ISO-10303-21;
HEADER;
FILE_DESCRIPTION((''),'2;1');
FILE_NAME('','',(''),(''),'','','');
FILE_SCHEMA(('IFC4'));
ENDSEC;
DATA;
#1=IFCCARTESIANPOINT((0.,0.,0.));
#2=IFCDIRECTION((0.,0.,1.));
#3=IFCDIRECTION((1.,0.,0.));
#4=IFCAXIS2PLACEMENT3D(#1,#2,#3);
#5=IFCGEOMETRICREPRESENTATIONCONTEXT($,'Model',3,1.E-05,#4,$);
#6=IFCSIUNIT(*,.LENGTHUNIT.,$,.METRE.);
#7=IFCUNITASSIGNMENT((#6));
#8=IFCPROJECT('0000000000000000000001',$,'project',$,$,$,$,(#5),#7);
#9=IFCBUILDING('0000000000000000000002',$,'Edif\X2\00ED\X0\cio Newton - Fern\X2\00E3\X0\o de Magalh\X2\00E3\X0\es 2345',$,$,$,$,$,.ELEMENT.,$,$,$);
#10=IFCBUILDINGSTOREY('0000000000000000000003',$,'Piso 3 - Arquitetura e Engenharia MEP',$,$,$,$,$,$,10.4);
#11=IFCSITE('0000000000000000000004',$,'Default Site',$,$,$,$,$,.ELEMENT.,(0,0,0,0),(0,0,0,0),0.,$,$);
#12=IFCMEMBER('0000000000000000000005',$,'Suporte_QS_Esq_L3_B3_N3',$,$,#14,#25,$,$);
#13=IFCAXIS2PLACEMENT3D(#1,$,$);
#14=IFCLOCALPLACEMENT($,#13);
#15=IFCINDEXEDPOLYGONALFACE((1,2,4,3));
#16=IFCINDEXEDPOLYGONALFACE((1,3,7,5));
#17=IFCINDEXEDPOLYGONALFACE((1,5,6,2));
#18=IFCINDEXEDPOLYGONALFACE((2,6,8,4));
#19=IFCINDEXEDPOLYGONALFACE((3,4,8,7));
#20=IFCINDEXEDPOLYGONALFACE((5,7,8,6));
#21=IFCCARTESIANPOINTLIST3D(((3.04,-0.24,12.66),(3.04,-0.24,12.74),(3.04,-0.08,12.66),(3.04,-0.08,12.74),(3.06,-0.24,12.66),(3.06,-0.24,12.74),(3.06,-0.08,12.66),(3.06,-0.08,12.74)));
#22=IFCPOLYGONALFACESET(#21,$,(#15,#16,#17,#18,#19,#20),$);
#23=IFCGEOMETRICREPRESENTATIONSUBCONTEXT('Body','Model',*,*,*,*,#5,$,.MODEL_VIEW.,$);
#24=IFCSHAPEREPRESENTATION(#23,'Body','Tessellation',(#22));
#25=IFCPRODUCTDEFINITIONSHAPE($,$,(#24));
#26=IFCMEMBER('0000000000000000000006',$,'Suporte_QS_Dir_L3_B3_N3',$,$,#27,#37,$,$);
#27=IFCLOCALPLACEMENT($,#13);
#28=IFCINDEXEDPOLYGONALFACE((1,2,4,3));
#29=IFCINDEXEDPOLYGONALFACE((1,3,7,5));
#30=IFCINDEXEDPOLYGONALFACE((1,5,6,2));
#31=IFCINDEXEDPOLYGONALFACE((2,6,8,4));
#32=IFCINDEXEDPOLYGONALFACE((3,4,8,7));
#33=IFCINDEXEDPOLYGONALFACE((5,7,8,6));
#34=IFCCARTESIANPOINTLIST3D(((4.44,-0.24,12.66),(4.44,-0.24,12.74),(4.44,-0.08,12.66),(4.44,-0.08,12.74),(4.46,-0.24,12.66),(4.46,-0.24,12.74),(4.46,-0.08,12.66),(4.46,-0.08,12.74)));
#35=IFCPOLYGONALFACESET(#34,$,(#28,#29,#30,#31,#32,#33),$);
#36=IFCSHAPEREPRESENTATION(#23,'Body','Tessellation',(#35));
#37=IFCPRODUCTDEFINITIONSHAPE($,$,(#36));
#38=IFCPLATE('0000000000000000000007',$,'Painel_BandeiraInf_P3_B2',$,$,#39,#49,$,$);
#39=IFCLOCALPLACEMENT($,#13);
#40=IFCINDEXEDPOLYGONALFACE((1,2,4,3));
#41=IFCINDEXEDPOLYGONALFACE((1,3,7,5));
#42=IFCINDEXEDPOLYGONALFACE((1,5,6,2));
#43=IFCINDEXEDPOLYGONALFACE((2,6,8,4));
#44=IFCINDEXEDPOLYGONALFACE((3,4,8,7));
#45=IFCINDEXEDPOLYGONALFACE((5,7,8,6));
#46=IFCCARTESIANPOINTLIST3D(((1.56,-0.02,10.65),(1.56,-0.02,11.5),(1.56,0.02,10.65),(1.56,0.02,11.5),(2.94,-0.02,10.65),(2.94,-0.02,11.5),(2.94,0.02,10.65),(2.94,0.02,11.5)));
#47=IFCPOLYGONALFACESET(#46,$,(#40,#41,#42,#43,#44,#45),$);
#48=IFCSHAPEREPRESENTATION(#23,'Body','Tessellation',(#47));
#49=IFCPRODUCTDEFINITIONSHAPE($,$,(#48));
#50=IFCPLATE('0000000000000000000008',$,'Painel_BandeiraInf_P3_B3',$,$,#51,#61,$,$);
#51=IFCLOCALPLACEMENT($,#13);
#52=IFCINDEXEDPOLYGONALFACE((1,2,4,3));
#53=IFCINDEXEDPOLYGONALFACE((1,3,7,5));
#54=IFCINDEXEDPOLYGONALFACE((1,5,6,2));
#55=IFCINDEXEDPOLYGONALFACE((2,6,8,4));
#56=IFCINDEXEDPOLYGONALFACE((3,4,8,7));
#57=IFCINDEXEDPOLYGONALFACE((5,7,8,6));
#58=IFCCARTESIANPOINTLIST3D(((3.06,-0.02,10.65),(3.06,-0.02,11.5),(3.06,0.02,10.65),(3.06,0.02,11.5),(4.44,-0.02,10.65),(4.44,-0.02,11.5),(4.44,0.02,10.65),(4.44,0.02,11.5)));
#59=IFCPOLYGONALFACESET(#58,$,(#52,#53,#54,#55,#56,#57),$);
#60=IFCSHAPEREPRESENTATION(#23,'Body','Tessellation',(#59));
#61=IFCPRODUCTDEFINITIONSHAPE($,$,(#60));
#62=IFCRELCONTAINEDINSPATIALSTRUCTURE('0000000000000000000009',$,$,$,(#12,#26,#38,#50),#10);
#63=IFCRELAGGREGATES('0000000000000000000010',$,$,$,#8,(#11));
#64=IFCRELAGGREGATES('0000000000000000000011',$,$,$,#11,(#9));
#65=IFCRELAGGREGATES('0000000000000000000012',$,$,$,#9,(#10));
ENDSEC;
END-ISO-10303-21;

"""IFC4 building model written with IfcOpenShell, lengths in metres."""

from ifc_helpers import new_model, si_unit, frame, frame_2d, origin_with_axes, place, context, subcontext, project, spatial, rectangle, extrude, element, save


model = new_model("IFC4")

# Units and contexts
model_context = context("Model", 3, precision=1e-05, world=origin_with_axes())
body_context = subcontext(model_context, "Body", "Model", "MODEL_VIEW")
ifc_project = project(units=[si_unit("LENGTHUNIT", "METRE")], contexts=[model_context])

# Site, building, storey
site = spatial("IfcSite", under=ifc_project, Name="Default Site", CompositionType="ELEMENT", RefLatitude=(0, 0, 0, 0), RefLongitude=(0, 0, 0, 0), RefElevation=0.0)
building = spatial("IfcBuilding", under=site, Name="Edifício Newton - Fernão de Magalhães 2345", CompositionType="ELEMENT")
storey = spatial("IfcBuildingStorey", under=building, Name="Piso 3 - Arquitetura e Engenharia MEP", Elevation=10.4)

# Members
for number, where, z_axis, x_axis, name in (
    (1, (3.04, -0.24, 12.66), (0.0, 0.0, 1.0), (1.0, 0.0, 0.0), "Suporte_QS_Esq_L3_B3_N3"),
    (2, (4.44, -0.24, 12.66), (0.0, 0.0, 1.0), (1.0, 0.0, 0.0), "Suporte_QS_Dir_L3_B3_N3"),
):
    element("IfcMember", number, at=place(None, frame(where, z_axis=z_axis, x_axis=x_axis)), inside=storey, Name=name, context=body_context, shape_type="SweptSolid", body=[
        extrude(rectangle(XDim=0.02, YDim=0.16, at=frame_2d((0.01, 0.08))), origin_with_axes(), (0.0, 0.0, 1.0), 0.08),
    ])

# Plates
for number, where, z_axis, x_axis, name in (
    (3, (1.56, -0.02, 10.65), (0.0, 0.0, 1.0), (1.0, 0.0, 0.0), "Painel_BandeiraInf_P3_B2"),
    (4, (3.06, -0.02, 10.65), (0.0, 0.0, 1.0), (1.0, 0.0, 0.0), "Painel_BandeiraInf_P3_B3"),
):
    element("IfcPlate", number, at=place(None, frame(where, z_axis=z_axis, x_axis=x_axis)), inside=storey, Name=name, context=body_context, shape_type="SweptSolid", body=[
        extrude(rectangle(XDim=1.38, YDim=0.04, at=frame_2d((0.69, 0.02))), origin_with_axes(), (0.0, 0.0, 1.0), 0.85),
    ])

save(model, "model.ifc")
